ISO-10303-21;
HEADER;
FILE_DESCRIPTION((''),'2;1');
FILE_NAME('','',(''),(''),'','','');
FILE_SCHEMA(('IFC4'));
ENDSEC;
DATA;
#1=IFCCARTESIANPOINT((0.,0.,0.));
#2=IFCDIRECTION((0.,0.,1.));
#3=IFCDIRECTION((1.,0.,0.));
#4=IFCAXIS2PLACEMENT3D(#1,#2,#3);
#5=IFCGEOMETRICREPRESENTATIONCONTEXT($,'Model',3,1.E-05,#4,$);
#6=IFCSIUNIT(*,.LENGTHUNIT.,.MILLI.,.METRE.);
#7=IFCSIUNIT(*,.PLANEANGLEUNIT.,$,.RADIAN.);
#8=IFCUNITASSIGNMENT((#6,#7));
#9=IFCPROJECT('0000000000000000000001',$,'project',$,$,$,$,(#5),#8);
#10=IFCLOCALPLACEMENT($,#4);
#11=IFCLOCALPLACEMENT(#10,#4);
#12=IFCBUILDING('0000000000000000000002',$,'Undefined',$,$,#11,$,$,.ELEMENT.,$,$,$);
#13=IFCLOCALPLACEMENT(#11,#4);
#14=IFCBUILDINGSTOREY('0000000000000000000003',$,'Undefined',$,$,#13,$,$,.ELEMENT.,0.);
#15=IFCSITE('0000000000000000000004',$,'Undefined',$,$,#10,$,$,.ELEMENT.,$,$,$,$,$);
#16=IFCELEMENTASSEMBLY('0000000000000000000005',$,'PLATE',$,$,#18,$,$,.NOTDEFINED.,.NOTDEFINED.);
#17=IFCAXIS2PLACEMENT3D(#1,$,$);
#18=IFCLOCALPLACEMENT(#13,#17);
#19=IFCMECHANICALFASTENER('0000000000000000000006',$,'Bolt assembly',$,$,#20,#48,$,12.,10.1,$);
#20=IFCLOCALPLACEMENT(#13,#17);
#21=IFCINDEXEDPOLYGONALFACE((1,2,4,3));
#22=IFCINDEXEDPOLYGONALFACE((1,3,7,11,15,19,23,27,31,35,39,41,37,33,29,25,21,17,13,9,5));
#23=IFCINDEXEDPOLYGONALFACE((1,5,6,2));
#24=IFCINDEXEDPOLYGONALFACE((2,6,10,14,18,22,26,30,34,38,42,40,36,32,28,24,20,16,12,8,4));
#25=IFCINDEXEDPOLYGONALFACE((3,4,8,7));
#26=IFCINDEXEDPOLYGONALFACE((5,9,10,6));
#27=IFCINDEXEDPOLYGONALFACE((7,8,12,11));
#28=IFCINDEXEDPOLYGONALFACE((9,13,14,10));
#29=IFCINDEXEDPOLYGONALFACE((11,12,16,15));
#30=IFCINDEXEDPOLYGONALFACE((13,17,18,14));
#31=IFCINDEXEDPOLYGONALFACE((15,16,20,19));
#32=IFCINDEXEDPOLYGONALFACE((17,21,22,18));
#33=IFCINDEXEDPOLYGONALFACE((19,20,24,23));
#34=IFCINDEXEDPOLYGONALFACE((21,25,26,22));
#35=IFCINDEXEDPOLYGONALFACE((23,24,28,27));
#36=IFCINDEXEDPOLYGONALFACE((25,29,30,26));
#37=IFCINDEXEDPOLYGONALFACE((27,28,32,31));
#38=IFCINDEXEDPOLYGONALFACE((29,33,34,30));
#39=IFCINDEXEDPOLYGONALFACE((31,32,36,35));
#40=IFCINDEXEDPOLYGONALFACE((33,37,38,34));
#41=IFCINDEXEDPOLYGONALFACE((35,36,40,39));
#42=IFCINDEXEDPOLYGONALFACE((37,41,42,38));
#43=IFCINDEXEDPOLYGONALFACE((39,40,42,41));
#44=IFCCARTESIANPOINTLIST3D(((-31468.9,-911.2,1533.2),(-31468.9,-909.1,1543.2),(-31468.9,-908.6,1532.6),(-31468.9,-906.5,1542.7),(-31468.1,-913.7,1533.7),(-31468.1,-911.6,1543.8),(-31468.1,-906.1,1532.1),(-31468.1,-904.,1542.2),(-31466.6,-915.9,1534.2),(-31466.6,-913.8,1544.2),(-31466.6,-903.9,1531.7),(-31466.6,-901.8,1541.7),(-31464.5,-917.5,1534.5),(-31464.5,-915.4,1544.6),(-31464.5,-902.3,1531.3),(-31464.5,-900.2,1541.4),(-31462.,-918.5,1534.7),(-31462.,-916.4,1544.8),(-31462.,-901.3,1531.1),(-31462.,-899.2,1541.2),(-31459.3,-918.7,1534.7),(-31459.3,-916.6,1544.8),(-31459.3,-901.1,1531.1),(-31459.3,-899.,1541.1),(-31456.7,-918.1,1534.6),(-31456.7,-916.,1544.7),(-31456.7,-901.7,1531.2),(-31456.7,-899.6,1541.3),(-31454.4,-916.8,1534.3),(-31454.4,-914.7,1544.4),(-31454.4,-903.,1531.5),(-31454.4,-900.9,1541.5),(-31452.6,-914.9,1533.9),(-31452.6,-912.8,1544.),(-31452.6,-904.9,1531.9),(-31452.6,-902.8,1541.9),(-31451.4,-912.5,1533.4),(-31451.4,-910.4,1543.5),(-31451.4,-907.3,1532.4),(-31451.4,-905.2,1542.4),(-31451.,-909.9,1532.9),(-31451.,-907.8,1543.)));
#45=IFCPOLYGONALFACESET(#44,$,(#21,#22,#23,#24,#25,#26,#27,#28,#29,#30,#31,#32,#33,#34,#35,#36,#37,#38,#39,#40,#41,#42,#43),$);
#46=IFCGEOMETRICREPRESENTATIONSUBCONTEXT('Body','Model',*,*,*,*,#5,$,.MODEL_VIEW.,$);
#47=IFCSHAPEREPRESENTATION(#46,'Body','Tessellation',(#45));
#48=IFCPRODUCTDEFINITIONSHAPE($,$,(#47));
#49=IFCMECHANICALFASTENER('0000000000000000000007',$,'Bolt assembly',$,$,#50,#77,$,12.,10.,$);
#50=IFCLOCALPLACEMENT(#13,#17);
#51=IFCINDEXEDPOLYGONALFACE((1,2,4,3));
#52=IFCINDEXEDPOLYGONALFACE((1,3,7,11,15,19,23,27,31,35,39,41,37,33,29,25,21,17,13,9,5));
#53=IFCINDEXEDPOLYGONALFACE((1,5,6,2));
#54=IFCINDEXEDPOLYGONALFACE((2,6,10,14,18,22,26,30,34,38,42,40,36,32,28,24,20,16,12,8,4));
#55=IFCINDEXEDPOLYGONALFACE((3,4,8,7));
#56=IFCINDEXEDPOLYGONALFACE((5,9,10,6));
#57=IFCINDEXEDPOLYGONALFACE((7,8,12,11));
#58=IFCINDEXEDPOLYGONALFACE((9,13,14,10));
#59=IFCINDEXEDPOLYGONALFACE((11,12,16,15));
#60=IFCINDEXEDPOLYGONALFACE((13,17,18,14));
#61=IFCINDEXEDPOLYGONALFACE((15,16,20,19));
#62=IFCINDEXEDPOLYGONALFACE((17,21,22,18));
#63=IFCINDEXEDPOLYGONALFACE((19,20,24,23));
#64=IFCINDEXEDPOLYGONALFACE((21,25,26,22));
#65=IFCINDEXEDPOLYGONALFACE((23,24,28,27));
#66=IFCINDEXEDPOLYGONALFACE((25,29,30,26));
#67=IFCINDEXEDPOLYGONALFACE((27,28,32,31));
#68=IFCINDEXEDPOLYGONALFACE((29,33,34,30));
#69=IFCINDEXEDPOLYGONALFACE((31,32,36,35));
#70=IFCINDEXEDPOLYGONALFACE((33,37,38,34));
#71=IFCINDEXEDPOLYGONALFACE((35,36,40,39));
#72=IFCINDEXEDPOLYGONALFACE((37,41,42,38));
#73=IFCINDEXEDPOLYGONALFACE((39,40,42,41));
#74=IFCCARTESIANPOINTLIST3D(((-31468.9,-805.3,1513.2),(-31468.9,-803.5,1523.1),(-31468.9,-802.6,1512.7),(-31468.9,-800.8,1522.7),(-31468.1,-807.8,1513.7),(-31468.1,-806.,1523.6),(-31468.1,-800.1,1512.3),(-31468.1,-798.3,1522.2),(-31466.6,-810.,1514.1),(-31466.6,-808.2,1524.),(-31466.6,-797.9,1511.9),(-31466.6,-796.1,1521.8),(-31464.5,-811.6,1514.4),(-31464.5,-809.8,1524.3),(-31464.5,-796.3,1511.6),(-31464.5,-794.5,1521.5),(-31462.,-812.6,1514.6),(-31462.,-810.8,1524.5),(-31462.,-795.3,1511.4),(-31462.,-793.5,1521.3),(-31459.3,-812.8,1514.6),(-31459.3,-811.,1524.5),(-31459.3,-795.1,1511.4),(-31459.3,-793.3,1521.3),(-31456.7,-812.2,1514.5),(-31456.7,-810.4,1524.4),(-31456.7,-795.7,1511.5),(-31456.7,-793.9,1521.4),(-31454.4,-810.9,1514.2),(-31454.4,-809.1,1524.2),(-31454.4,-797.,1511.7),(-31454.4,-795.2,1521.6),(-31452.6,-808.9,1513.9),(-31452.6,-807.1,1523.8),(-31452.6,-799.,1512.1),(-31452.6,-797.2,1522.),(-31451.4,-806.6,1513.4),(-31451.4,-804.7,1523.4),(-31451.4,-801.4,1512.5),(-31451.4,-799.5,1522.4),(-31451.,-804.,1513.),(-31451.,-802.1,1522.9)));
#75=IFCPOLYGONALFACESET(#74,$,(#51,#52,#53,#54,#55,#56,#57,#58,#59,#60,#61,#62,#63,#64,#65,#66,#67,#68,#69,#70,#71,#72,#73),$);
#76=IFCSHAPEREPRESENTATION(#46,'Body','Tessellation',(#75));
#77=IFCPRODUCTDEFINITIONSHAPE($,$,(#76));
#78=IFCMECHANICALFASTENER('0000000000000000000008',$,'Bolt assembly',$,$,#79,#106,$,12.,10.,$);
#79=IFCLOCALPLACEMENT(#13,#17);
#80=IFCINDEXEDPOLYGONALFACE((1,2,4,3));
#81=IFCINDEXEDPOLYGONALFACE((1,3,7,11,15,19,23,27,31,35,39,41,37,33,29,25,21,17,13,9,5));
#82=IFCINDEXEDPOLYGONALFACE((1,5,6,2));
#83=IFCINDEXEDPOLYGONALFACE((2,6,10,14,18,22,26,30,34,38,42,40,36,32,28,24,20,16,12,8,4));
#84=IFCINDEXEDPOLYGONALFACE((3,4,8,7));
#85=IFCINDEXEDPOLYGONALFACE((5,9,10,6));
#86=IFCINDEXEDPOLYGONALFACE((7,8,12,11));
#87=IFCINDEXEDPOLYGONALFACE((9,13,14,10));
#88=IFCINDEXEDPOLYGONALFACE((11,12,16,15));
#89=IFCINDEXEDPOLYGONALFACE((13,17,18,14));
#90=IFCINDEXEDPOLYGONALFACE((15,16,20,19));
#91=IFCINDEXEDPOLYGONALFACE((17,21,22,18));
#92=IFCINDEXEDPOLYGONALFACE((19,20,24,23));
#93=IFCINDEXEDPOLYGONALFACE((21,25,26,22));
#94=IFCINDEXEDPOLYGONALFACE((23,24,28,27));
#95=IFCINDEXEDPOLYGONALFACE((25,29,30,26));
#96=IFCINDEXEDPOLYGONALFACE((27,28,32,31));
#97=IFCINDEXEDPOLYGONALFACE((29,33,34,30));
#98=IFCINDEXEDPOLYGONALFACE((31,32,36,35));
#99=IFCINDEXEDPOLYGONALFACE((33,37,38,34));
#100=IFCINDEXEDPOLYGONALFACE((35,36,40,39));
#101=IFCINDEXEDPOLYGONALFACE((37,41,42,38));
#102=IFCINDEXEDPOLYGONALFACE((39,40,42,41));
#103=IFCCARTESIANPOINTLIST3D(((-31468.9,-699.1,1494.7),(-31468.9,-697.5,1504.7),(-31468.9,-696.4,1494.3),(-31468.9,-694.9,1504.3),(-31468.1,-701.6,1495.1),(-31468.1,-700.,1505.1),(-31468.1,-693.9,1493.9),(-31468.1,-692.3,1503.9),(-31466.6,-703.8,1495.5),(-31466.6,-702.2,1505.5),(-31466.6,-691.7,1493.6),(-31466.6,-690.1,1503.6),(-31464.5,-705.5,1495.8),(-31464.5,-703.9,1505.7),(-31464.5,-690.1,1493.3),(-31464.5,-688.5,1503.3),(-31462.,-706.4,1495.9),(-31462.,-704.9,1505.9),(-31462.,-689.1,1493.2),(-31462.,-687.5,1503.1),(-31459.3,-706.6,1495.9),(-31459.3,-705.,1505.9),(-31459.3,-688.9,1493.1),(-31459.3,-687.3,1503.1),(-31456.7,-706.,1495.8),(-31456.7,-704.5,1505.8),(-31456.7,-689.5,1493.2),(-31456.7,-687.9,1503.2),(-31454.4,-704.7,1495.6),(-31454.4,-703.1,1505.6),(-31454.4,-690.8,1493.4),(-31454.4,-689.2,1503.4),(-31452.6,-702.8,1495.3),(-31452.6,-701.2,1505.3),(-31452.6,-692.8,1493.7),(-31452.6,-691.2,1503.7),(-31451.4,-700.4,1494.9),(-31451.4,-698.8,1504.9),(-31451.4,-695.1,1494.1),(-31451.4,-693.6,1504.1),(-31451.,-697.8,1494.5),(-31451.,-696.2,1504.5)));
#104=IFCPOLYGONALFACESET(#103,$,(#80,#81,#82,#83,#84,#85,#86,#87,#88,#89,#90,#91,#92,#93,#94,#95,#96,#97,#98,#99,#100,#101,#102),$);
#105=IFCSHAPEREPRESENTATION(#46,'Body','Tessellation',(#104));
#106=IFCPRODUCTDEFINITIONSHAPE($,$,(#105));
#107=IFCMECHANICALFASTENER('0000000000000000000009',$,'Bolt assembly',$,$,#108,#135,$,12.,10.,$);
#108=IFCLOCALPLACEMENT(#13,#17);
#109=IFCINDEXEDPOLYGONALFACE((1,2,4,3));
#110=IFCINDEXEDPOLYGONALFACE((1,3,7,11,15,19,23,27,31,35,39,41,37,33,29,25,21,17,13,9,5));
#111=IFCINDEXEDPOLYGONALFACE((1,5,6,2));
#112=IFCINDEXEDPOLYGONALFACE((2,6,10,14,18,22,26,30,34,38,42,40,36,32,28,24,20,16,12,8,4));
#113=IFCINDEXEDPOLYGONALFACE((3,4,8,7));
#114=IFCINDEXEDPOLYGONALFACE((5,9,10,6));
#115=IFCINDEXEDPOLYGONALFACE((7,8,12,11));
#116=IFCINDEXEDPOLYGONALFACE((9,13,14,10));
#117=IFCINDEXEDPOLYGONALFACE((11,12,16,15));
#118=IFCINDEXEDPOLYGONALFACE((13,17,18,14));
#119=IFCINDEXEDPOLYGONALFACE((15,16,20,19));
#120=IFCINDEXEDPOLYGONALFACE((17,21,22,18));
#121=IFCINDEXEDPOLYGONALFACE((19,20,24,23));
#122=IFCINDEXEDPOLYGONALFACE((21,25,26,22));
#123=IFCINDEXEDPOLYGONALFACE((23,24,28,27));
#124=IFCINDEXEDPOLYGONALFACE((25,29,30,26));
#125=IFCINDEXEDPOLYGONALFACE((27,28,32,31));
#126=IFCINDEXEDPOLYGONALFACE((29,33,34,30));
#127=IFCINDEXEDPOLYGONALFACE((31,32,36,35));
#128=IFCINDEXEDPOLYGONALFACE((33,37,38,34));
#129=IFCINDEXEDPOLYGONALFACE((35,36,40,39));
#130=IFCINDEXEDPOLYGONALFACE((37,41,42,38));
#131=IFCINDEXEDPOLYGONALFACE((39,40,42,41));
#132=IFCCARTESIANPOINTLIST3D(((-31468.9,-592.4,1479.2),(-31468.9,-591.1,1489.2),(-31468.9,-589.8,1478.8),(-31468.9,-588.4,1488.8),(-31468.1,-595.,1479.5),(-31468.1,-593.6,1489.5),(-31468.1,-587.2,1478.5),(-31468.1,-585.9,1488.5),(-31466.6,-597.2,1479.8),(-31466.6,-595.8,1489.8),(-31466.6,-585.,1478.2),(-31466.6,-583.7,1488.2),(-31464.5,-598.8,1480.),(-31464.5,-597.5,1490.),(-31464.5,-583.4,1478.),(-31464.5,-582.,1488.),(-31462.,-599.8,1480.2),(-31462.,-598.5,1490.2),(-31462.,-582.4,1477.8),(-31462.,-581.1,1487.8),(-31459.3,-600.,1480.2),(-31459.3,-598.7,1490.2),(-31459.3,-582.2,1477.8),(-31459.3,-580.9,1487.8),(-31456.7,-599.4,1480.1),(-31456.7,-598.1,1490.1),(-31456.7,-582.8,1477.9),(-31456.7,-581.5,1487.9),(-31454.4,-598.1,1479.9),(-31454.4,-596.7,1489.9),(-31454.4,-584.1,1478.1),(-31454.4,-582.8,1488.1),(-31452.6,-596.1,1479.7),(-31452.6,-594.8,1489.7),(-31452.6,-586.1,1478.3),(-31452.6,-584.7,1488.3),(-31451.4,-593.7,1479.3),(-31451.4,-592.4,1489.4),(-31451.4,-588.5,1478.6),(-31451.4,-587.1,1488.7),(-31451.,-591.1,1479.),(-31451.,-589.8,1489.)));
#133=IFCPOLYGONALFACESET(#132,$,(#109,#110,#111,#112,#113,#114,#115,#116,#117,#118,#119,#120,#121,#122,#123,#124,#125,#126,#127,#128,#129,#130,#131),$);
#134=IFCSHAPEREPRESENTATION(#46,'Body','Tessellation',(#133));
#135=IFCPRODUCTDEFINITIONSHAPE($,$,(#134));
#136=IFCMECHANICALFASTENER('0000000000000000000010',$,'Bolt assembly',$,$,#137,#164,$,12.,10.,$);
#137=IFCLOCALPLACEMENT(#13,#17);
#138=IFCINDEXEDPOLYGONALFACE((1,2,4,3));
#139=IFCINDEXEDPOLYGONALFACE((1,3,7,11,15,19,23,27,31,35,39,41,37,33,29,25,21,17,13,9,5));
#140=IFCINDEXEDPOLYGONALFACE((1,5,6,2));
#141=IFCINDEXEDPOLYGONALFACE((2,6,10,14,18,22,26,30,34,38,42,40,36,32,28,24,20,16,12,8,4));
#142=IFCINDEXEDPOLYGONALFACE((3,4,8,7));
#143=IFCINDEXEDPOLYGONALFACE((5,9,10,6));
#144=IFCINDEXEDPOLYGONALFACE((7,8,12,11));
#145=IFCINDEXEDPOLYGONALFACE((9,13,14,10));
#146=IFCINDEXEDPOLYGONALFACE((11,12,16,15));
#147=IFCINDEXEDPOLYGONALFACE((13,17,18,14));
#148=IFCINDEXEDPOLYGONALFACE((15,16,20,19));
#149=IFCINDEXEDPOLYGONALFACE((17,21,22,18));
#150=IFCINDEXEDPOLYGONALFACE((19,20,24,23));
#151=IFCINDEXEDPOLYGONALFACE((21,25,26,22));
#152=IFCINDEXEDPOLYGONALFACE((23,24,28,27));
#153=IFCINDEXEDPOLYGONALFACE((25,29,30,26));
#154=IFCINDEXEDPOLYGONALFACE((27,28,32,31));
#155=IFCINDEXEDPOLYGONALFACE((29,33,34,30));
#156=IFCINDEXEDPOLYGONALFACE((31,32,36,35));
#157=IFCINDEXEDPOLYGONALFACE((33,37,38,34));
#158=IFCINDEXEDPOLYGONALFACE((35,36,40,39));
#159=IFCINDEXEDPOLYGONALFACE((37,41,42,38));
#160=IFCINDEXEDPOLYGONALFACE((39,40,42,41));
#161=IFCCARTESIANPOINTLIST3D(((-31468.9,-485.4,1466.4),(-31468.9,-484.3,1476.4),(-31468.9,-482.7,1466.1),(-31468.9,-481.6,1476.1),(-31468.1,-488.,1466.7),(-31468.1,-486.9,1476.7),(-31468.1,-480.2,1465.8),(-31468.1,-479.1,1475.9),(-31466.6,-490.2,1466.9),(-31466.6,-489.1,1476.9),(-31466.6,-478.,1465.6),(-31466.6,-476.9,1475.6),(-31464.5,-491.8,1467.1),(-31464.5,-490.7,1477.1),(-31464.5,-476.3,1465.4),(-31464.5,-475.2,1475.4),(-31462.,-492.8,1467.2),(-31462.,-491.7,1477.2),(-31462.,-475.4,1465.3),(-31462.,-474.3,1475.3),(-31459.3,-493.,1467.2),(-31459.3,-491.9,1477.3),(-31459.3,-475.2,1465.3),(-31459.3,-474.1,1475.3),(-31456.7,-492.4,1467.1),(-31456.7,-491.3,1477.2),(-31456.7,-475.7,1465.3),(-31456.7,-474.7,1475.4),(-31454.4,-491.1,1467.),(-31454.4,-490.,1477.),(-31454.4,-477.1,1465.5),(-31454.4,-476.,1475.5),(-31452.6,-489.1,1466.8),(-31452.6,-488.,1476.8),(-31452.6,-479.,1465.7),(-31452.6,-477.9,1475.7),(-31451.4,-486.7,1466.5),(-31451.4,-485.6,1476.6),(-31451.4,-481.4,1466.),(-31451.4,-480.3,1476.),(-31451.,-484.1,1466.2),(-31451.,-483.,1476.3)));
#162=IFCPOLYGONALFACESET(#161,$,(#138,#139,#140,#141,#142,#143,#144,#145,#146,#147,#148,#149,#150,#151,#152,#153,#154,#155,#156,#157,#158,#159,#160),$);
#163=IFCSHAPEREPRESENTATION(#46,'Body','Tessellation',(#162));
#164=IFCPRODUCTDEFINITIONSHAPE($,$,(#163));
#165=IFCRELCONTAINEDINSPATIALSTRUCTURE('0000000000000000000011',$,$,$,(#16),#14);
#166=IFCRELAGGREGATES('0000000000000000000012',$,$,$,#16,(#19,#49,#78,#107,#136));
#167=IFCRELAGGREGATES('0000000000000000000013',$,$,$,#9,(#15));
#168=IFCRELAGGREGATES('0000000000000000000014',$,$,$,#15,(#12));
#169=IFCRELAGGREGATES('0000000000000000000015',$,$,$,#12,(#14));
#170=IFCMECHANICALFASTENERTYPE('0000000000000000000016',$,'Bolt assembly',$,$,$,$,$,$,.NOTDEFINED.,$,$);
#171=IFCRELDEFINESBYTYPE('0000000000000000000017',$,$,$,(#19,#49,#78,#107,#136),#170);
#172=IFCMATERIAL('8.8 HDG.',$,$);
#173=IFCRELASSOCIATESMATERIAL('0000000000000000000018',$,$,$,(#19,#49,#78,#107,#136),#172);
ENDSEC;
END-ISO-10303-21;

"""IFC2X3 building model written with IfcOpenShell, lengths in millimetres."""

from ifc_helpers import new_model, si_unit, frame, origin_with_axes, origin_2d_with_axis, place, context, subcontext, project, spatial, circle, extrude, source, transform, mapped, material, type_object, element, aggregate, save


model = new_model("IFC2X3")

# Units and contexts
model_context = context("Model", 3, precision=1e-05, world=origin_with_axes())
body_context = subcontext(model_context, "Body", "Model", "MODEL_VIEW")
ifc_project = project(units=[si_unit("LENGTHUNIT", "METRE", prefix="MILLI"), si_unit("PLANEANGLEUNIT", "RADIAN")], contexts=[model_context])

# Site, building, storey
site_placement = place(None, origin_with_axes())
site = spatial("IfcSite", under=ifc_project, at=site_placement, Name="Undefined", CompositionType="ELEMENT")
building_placement = place(site_placement, origin_with_axes())
building = spatial("IfcBuilding", under=site, at=building_placement, Name="Undefined", CompositionType="ELEMENT")
storey_placement = place(building_placement, origin_with_axes())
storey = spatial("IfcBuildingStorey", under=building, at=storey_placement, Name="Undefined", CompositionType="ELEMENT", Elevation=0.0)

# Element assembly, mechanical fasteners
assembly_placement = place(storey_placement, origin_with_axes())
assembly = element("IfcElementAssembly", 1, at=assembly_placement, inside=storey, Name="PLATE", AssemblyPlace="NOTDEFINED", PredefinedType="NOTDEFINED")
ifc_material_1 = material(Name="8.8 HDG.")
mechanical_fastener_type = type_object("IfcMechanicalFastenerType", Name="Bolt assembly")
shared_shape_1 = source(origin_with_axes(), body_context, "Body", "SweptSolid", [
    extrude(circle(Radius=9.0, at=origin_2d_with_axis()), frame((0.0, 0.1, 0.0), z_axis=(0.0, 1.0, 0.0), x_axis=(1.0, 0.0, 0.0)), (0.0, 0.0, 1.0), 10.3),
])
mechanical_fastener_1_placement = place(assembly_placement, frame((-31460.0, -909.9, 1532.8), z_axis=(0.000001, -0.978977, 0.20397), x_axis=(1.0, 0.000001, -0.000001)))
mechanical_fastener_1 = element("IfcMechanicalFastener", 2, at=mechanical_fastener_1_placement, type_object=mechanical_fastener_type, material=ifc_material_1, Name="Bolt assembly", NominalDiameter=12.0, NominalLength=10.1, context=body_context, shape_type="MappedRepresentation", body=[
    mapped(shared_shape_1, transform((0.0, 0.0, 0.0))),
])
shared_shape_2 = source(origin_with_axes(), body_context, "Body", "SweptSolid", [
    extrude(circle(Radius=9.0, at=origin_2d_with_axis()), frame((0.0, 0.9, 0.0), z_axis=(0.0, 1.0, 0.0), x_axis=(1.0, 0.0, 0.0)), (0.0, 0.0, 1.0), 10.1),
])
mechanical_fastener_2_placement = place(assembly_placement, frame((-31460.0, -804.1, 1512.1), z_axis=(0.000001, -0.98362, 0.180255), x_axis=(1.0, 0.000001, -0.000001)))
mechanical_fastener_2 = element("IfcMechanicalFastener", 3, at=mechanical_fastener_2_placement, type_object=mechanical_fastener_type, material=ifc_material_1, Name="Bolt assembly", NominalDiameter=12.0, NominalLength=10.0, context=body_context, shape_type="MappedRepresentation", body=[
    mapped(shared_shape_2, transform((0.0, 0.0, 0.0))),
])
shared_shape_3 = source(origin_with_axes(), body_context, "Body", "SweptSolid", [
    extrude(circle(Radius=9.0, at=origin_2d_with_axis()), frame((0.0, 0.6, 0.0), z_axis=(0.0, 1.0, 0.0), x_axis=(1.0, 0.0, 0.0)), (0.0, 0.0, 1.0), 10.1),
])
mechanical_fastener_3_placement = place(assembly_placement, frame((-31460.0, -697.9, 1494.0), z_axis=(0.000001, -0.987688, 0.156435), x_axis=(1.0, 0.000001, -0.000001)))
mechanical_fastener_3 = element("IfcMechanicalFastener", 4, at=mechanical_fastener_3_placement, type_object=mechanical_fastener_type, material=ifc_material_1, Name="Bolt assembly", NominalDiameter=12.0, NominalLength=10.0, context=body_context, shape_type="MappedRepresentation", body=[
    mapped(shared_shape_3, transform((0.0, 0.0, 0.0))),
])
shared_shape_4 = source(origin_with_axes(), body_context, "Body", "SweptSolid", [
    extrude(circle(Radius=9.0, at=origin_2d_with_axis()), frame((0.0, 0.6, 0.0), z_axis=(0.0, 1.0, 0.0), x_axis=(1.0, 0.0, 0.0)), (0.0, 0.0, 1.0), 10.1),
])
mechanical_fastener_4_placement = place(assembly_placement, frame((-31460.0, -591.2, 1478.4), z_axis=(0.000001, -0.99118, 0.132523), x_axis=(1.0, 0.000001, -0.000001)))
mechanical_fastener_4 = element("IfcMechanicalFastener", 5, at=mechanical_fastener_4_placement, type_object=mechanical_fastener_type, material=ifc_material_1, Name="Bolt assembly", NominalDiameter=12.0, NominalLength=10.0, context=body_context, shape_type="MappedRepresentation", body=[
    mapped(shared_shape_4, transform((0.0, 0.0, 0.0))),
])
shared_shape_5 = source(origin_with_axes(), body_context, "Body", "SweptSolid", [
    extrude(circle(Radius=9.0, at=origin_2d_with_axis()), frame((0.0, 0.8, 0.0), z_axis=(0.0, 1.0, 0.0), x_axis=(1.0, 0.0, 0.0)), (0.0, 0.0, 1.0), 10.1),
])
mechanical_fastener_5_placement = place(assembly_placement, frame((-31460.0, -484.2, 1465.4), z_axis=(0.000001, -0.994093, 0.108533), x_axis=(1.0, 0.000001, -0.000001)))
mechanical_fastener_5 = element("IfcMechanicalFastener", 6, at=mechanical_fastener_5_placement, type_object=mechanical_fastener_type, material=ifc_material_1, Name="Bolt assembly", NominalDiameter=12.0, NominalLength=10.0, context=body_context, shape_type="MappedRepresentation", body=[
    mapped(shared_shape_5, transform((0.0, 0.0, 0.0))),
])
aggregate(assembly, [mechanical_fastener_1, mechanical_fastener_2, mechanical_fastener_3, mechanical_fastener_4, mechanical_fastener_5])

save(model, "model.ifc")
